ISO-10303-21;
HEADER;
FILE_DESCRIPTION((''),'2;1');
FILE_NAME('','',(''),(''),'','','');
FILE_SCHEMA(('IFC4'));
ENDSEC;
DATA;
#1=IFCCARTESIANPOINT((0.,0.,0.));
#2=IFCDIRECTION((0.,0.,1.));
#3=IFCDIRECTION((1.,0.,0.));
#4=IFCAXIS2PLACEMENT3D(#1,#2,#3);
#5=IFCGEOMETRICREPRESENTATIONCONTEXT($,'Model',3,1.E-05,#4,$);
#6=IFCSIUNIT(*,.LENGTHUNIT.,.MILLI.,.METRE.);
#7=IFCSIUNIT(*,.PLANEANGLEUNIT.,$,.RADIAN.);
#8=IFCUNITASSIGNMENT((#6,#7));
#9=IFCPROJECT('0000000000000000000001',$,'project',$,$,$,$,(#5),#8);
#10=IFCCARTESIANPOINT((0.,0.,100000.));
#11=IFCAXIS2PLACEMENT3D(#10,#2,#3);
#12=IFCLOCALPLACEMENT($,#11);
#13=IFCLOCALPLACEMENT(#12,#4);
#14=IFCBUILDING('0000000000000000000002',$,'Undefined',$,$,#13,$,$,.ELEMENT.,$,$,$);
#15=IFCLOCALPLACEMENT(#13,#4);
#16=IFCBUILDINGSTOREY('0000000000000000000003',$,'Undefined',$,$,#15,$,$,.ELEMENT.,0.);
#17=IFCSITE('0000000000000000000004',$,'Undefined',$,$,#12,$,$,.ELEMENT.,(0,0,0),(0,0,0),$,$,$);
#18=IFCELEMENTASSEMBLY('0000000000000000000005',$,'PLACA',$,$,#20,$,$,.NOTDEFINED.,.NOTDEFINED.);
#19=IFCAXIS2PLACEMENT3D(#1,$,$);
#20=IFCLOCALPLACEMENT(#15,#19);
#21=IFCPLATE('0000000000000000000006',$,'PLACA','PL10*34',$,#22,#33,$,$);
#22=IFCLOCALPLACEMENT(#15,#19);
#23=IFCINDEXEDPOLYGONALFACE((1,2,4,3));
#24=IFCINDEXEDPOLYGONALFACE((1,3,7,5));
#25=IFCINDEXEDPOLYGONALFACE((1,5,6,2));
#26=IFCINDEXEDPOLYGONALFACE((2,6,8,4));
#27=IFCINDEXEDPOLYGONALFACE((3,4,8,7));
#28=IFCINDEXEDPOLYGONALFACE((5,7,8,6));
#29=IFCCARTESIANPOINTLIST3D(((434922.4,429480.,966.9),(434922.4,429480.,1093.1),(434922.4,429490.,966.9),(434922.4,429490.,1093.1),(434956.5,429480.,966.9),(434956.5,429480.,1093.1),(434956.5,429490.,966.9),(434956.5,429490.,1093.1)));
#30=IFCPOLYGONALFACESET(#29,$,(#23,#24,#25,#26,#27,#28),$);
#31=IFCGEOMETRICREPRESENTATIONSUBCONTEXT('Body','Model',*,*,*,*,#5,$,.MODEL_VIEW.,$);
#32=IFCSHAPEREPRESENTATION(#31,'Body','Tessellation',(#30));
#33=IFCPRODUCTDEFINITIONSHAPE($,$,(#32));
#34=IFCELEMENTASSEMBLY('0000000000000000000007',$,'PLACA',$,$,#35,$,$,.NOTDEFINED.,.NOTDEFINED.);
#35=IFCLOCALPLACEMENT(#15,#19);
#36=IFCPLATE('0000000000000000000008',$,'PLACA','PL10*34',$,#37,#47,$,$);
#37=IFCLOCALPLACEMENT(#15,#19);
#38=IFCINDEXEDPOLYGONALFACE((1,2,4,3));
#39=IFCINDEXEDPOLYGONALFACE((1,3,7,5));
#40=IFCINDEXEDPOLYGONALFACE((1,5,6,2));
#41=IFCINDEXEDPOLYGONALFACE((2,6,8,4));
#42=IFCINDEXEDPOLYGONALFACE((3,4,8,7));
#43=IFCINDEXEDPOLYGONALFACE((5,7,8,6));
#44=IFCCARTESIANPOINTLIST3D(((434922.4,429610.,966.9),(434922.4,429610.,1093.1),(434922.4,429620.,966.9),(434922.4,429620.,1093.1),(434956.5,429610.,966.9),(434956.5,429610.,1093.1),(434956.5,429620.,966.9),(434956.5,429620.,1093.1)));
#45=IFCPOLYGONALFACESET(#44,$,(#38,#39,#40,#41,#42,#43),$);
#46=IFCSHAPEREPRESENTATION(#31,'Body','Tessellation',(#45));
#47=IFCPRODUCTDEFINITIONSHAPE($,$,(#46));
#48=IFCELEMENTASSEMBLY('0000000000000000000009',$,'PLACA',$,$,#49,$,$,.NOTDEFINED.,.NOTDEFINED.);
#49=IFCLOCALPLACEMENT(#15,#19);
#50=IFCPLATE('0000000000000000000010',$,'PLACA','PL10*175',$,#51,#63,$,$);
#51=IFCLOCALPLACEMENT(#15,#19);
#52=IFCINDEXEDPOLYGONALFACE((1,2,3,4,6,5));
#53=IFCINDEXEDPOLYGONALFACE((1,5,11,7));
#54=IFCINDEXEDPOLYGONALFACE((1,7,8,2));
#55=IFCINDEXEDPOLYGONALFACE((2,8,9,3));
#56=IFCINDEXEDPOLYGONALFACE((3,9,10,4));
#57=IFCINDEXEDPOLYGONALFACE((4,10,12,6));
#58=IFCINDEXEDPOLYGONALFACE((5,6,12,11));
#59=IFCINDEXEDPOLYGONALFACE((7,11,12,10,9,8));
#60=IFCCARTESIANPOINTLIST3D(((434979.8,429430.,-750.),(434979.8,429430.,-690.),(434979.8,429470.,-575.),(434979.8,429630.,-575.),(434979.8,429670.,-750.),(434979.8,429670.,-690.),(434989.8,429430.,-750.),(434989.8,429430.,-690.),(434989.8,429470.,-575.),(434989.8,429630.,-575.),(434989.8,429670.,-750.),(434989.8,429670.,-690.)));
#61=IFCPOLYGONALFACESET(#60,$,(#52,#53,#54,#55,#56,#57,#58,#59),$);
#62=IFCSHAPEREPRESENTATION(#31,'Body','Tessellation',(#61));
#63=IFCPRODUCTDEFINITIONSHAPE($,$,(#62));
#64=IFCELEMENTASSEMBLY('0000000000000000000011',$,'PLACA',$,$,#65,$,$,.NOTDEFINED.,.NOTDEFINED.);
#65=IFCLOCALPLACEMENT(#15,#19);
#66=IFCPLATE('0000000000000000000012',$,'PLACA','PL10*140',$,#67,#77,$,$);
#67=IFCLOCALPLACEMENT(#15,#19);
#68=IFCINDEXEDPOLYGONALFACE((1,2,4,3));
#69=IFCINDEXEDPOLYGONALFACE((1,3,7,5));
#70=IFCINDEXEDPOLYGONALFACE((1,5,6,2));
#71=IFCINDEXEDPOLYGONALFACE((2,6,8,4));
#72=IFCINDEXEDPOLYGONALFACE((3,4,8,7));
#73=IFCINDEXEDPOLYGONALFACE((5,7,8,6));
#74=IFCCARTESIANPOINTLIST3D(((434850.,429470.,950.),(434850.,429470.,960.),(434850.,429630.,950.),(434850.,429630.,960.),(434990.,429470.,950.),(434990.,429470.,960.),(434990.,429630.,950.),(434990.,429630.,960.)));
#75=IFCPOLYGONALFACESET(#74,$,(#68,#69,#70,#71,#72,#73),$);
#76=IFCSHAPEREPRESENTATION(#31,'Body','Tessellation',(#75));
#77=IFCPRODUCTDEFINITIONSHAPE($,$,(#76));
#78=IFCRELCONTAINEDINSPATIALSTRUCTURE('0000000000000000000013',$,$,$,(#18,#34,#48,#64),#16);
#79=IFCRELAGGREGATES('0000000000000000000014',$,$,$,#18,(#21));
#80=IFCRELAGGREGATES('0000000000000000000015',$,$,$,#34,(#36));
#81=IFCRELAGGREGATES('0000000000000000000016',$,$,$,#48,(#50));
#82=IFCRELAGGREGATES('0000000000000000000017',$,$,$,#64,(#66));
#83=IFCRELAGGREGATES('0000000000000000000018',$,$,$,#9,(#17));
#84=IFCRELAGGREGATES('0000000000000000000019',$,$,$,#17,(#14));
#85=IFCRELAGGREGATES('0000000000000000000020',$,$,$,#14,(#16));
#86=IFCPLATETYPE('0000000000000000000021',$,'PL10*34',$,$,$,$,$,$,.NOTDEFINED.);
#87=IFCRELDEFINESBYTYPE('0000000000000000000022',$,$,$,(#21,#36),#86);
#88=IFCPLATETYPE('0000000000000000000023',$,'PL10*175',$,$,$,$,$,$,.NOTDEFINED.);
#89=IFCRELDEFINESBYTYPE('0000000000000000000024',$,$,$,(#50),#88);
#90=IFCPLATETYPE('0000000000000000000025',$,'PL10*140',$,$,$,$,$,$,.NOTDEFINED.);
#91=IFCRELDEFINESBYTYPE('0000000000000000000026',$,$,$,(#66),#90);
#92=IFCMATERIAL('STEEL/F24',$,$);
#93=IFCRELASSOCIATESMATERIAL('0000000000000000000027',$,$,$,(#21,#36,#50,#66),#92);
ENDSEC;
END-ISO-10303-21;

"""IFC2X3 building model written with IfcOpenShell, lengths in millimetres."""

from ifc_helpers import new_model, si_unit, frame, origin_with_axes, place, context, subcontext, project, spatial, polyline, outline, extrude, material, type_object, element, aggregate, save


model = new_model("IFC2X3")

# Units and contexts
model_context = context("Model", 3, precision=1e-05, world=origin_with_axes())
body_context = subcontext(model_context, "Body", "Model", "MODEL_VIEW")
ifc_project = project(units=[si_unit("LENGTHUNIT", "METRE", prefix="MILLI"), si_unit("PLANEANGLEUNIT", "RADIAN")], contexts=[model_context])

# Site, building, storey
site_placement = place(None, frame((0.0, 0.0, 100000.0), z_axis=(0.0, 0.0, 1.0), x_axis=(1.0, 0.0, 0.0)))
site = spatial("IfcSite", under=ifc_project, at=site_placement, Name="Undefined", CompositionType="ELEMENT", RefLatitude=(0, 0, 0), RefLongitude=(0, 0, 0))
building_placement = place(site_placement, origin_with_axes())
building = spatial("IfcBuilding", under=site, at=building_placement, Name="Undefined", CompositionType="ELEMENT")
storey_placement = place(building_placement, origin_with_axes())
storey = spatial("IfcBuildingStorey", under=building, at=storey_placement, Name="Undefined", CompositionType="ELEMENT", Elevation=0.0)

# Shared definitions
ifc_material_1 = material(Name="STEEL/F24")

# Element assemblies, plates
assembly_1_placement = place(storey_placement, origin_with_axes())
assembly_1 = element("IfcElementAssembly", 1, at=assembly_1_placement, inside=storey, Name="PLACA", AssemblyPlace="NOTDEFINED", PredefinedType="NOTDEFINED")
plate_type_1 = type_object("IfcPlateType", Name="PL10*34", PredefinedType="NOTDEFINED")
plate_1_placement = place(assembly_1_placement, frame((434922.4, 429485.0, 966.9), z_axis=(0.0, 1.0, 0.0), x_axis=(0.0, 0.0, 1.0)))
plate_1 = element("IfcPlate", 2, at=plate_1_placement, type_object=plate_type_1, material=ifc_material_1, Name="PLACA", Description="PL10*34", context=body_context, shape_type="SweptSolid", body=[
    extrude(outline(polyline([(0.0, 0.0), (126.2, 0.0), (126.2, 34.2), (0.0, 34.2), (0.0, 0.0)])), frame((0.0, 0.0, -5.0), z_axis=(0.0, 0.0, 1.0), x_axis=(1.0, 0.0, 0.0)), (0.0, 0.0, 1.0), 10.0),
])
aggregate(assembly_1, [plate_1])
assembly_2_placement = place(storey_placement, origin_with_axes())
assembly_2 = element("IfcElementAssembly", 3, at=assembly_2_placement, inside=storey, Name="PLACA", AssemblyPlace="NOTDEFINED", PredefinedType="NOTDEFINED")
plate_2_placement = place(assembly_2_placement, frame((434922.4, 429615.0, 966.9), z_axis=(0.0, 1.0, 0.0), x_axis=(0.0, 0.0, 1.0)))
plate_2 = element("IfcPlate", 4, at=plate_2_placement, type_object=plate_type_1, material=ifc_material_1, Name="PLACA", Description="PL10*34", context=body_context, shape_type="SweptSolid", body=[
    extrude(outline(polyline([(0.0, 0.0), (126.2, 0.0), (126.2, 34.2), (0.0, 34.2), (0.0, 0.0)])), frame((0.0, 0.0, -5.0), z_axis=(0.0, 0.0, 1.0), x_axis=(1.0, 0.0, 0.0)), (0.0, 0.0, 1.0), 10.0),
])
aggregate(assembly_2, [plate_2])
assembly_3_placement = place(storey_placement, origin_with_axes())
assembly_3 = element("IfcElementAssembly", 5, at=assembly_3_placement, inside=storey, Name="PLACA", AssemblyPlace="NOTDEFINED", PredefinedType="NOTDEFINED")
plate_type_2 = type_object("IfcPlateType", Name="PL10*175", PredefinedType="NOTDEFINED")
plate_3_placement = place(assembly_3_placement, frame((434984.8, 429630.0, -575.0), z_axis=(1.0, 0.0, 0.0), x_axis=(0.0, -1.0, 0.0)))
plate_3 = element("IfcPlate", 6, at=plate_3_placement, type_object=plate_type_2, material=ifc_material_1, Name="PLACA", Description="PL10*175", context=body_context, shape_type="SweptSolid", body=[
    extrude(outline(polyline([(0.0, 0.0), (160.0, 0.0), (200.0, 115.0), (200.0, 175.0), (-40.0, 175.0), (-40.0, 115.0), (0.0, 0.0)])), frame((0.0, 0.0, -5.0), z_axis=(0.0, 0.0, 1.0), x_axis=(1.0, 0.0, 0.0)), (0.0, 0.0, 1.0), 10.0),
])
aggregate(assembly_3, [plate_3])
assembly_4_placement = place(storey_placement, origin_with_axes())
assembly_4 = element("IfcElementAssembly", 7, at=assembly_4_placement, inside=storey, Name="PLACA", AssemblyPlace="NOTDEFINED", PredefinedType="NOTDEFINED")
plate_type_3 = type_object("IfcPlateType", Name="PL10*140", PredefinedType="NOTDEFINED")
plate_4_placement = place(assembly_4_placement, frame((434990.0, 429630.0, 955.0), z_axis=(0.0, 0.0, 1.0), x_axis=(-1.0, 0.0, 0.0)))
plate_4 = element("IfcPlate", 8, at=plate_4_placement, type_object=plate_type_3, material=ifc_material_1, Name="PLACA", Description="PL10*140", context=body_context, shape_type="SweptSolid", body=[
    extrude(outline(polyline([(0.0, 0.0), (140.0, 0.0), (140.0, 160.0), (0.0, 160.0), (0.0, 0.0)])), frame((0.0, 0.0, -5.0), z_axis=(0.0, 0.0, 1.0), x_axis=(1.0, 0.0, 0.0)), (0.0, 0.0, 1.0), 10.0),
])
aggregate(assembly_4, [plate_4])

save(model, "model.ifc")
